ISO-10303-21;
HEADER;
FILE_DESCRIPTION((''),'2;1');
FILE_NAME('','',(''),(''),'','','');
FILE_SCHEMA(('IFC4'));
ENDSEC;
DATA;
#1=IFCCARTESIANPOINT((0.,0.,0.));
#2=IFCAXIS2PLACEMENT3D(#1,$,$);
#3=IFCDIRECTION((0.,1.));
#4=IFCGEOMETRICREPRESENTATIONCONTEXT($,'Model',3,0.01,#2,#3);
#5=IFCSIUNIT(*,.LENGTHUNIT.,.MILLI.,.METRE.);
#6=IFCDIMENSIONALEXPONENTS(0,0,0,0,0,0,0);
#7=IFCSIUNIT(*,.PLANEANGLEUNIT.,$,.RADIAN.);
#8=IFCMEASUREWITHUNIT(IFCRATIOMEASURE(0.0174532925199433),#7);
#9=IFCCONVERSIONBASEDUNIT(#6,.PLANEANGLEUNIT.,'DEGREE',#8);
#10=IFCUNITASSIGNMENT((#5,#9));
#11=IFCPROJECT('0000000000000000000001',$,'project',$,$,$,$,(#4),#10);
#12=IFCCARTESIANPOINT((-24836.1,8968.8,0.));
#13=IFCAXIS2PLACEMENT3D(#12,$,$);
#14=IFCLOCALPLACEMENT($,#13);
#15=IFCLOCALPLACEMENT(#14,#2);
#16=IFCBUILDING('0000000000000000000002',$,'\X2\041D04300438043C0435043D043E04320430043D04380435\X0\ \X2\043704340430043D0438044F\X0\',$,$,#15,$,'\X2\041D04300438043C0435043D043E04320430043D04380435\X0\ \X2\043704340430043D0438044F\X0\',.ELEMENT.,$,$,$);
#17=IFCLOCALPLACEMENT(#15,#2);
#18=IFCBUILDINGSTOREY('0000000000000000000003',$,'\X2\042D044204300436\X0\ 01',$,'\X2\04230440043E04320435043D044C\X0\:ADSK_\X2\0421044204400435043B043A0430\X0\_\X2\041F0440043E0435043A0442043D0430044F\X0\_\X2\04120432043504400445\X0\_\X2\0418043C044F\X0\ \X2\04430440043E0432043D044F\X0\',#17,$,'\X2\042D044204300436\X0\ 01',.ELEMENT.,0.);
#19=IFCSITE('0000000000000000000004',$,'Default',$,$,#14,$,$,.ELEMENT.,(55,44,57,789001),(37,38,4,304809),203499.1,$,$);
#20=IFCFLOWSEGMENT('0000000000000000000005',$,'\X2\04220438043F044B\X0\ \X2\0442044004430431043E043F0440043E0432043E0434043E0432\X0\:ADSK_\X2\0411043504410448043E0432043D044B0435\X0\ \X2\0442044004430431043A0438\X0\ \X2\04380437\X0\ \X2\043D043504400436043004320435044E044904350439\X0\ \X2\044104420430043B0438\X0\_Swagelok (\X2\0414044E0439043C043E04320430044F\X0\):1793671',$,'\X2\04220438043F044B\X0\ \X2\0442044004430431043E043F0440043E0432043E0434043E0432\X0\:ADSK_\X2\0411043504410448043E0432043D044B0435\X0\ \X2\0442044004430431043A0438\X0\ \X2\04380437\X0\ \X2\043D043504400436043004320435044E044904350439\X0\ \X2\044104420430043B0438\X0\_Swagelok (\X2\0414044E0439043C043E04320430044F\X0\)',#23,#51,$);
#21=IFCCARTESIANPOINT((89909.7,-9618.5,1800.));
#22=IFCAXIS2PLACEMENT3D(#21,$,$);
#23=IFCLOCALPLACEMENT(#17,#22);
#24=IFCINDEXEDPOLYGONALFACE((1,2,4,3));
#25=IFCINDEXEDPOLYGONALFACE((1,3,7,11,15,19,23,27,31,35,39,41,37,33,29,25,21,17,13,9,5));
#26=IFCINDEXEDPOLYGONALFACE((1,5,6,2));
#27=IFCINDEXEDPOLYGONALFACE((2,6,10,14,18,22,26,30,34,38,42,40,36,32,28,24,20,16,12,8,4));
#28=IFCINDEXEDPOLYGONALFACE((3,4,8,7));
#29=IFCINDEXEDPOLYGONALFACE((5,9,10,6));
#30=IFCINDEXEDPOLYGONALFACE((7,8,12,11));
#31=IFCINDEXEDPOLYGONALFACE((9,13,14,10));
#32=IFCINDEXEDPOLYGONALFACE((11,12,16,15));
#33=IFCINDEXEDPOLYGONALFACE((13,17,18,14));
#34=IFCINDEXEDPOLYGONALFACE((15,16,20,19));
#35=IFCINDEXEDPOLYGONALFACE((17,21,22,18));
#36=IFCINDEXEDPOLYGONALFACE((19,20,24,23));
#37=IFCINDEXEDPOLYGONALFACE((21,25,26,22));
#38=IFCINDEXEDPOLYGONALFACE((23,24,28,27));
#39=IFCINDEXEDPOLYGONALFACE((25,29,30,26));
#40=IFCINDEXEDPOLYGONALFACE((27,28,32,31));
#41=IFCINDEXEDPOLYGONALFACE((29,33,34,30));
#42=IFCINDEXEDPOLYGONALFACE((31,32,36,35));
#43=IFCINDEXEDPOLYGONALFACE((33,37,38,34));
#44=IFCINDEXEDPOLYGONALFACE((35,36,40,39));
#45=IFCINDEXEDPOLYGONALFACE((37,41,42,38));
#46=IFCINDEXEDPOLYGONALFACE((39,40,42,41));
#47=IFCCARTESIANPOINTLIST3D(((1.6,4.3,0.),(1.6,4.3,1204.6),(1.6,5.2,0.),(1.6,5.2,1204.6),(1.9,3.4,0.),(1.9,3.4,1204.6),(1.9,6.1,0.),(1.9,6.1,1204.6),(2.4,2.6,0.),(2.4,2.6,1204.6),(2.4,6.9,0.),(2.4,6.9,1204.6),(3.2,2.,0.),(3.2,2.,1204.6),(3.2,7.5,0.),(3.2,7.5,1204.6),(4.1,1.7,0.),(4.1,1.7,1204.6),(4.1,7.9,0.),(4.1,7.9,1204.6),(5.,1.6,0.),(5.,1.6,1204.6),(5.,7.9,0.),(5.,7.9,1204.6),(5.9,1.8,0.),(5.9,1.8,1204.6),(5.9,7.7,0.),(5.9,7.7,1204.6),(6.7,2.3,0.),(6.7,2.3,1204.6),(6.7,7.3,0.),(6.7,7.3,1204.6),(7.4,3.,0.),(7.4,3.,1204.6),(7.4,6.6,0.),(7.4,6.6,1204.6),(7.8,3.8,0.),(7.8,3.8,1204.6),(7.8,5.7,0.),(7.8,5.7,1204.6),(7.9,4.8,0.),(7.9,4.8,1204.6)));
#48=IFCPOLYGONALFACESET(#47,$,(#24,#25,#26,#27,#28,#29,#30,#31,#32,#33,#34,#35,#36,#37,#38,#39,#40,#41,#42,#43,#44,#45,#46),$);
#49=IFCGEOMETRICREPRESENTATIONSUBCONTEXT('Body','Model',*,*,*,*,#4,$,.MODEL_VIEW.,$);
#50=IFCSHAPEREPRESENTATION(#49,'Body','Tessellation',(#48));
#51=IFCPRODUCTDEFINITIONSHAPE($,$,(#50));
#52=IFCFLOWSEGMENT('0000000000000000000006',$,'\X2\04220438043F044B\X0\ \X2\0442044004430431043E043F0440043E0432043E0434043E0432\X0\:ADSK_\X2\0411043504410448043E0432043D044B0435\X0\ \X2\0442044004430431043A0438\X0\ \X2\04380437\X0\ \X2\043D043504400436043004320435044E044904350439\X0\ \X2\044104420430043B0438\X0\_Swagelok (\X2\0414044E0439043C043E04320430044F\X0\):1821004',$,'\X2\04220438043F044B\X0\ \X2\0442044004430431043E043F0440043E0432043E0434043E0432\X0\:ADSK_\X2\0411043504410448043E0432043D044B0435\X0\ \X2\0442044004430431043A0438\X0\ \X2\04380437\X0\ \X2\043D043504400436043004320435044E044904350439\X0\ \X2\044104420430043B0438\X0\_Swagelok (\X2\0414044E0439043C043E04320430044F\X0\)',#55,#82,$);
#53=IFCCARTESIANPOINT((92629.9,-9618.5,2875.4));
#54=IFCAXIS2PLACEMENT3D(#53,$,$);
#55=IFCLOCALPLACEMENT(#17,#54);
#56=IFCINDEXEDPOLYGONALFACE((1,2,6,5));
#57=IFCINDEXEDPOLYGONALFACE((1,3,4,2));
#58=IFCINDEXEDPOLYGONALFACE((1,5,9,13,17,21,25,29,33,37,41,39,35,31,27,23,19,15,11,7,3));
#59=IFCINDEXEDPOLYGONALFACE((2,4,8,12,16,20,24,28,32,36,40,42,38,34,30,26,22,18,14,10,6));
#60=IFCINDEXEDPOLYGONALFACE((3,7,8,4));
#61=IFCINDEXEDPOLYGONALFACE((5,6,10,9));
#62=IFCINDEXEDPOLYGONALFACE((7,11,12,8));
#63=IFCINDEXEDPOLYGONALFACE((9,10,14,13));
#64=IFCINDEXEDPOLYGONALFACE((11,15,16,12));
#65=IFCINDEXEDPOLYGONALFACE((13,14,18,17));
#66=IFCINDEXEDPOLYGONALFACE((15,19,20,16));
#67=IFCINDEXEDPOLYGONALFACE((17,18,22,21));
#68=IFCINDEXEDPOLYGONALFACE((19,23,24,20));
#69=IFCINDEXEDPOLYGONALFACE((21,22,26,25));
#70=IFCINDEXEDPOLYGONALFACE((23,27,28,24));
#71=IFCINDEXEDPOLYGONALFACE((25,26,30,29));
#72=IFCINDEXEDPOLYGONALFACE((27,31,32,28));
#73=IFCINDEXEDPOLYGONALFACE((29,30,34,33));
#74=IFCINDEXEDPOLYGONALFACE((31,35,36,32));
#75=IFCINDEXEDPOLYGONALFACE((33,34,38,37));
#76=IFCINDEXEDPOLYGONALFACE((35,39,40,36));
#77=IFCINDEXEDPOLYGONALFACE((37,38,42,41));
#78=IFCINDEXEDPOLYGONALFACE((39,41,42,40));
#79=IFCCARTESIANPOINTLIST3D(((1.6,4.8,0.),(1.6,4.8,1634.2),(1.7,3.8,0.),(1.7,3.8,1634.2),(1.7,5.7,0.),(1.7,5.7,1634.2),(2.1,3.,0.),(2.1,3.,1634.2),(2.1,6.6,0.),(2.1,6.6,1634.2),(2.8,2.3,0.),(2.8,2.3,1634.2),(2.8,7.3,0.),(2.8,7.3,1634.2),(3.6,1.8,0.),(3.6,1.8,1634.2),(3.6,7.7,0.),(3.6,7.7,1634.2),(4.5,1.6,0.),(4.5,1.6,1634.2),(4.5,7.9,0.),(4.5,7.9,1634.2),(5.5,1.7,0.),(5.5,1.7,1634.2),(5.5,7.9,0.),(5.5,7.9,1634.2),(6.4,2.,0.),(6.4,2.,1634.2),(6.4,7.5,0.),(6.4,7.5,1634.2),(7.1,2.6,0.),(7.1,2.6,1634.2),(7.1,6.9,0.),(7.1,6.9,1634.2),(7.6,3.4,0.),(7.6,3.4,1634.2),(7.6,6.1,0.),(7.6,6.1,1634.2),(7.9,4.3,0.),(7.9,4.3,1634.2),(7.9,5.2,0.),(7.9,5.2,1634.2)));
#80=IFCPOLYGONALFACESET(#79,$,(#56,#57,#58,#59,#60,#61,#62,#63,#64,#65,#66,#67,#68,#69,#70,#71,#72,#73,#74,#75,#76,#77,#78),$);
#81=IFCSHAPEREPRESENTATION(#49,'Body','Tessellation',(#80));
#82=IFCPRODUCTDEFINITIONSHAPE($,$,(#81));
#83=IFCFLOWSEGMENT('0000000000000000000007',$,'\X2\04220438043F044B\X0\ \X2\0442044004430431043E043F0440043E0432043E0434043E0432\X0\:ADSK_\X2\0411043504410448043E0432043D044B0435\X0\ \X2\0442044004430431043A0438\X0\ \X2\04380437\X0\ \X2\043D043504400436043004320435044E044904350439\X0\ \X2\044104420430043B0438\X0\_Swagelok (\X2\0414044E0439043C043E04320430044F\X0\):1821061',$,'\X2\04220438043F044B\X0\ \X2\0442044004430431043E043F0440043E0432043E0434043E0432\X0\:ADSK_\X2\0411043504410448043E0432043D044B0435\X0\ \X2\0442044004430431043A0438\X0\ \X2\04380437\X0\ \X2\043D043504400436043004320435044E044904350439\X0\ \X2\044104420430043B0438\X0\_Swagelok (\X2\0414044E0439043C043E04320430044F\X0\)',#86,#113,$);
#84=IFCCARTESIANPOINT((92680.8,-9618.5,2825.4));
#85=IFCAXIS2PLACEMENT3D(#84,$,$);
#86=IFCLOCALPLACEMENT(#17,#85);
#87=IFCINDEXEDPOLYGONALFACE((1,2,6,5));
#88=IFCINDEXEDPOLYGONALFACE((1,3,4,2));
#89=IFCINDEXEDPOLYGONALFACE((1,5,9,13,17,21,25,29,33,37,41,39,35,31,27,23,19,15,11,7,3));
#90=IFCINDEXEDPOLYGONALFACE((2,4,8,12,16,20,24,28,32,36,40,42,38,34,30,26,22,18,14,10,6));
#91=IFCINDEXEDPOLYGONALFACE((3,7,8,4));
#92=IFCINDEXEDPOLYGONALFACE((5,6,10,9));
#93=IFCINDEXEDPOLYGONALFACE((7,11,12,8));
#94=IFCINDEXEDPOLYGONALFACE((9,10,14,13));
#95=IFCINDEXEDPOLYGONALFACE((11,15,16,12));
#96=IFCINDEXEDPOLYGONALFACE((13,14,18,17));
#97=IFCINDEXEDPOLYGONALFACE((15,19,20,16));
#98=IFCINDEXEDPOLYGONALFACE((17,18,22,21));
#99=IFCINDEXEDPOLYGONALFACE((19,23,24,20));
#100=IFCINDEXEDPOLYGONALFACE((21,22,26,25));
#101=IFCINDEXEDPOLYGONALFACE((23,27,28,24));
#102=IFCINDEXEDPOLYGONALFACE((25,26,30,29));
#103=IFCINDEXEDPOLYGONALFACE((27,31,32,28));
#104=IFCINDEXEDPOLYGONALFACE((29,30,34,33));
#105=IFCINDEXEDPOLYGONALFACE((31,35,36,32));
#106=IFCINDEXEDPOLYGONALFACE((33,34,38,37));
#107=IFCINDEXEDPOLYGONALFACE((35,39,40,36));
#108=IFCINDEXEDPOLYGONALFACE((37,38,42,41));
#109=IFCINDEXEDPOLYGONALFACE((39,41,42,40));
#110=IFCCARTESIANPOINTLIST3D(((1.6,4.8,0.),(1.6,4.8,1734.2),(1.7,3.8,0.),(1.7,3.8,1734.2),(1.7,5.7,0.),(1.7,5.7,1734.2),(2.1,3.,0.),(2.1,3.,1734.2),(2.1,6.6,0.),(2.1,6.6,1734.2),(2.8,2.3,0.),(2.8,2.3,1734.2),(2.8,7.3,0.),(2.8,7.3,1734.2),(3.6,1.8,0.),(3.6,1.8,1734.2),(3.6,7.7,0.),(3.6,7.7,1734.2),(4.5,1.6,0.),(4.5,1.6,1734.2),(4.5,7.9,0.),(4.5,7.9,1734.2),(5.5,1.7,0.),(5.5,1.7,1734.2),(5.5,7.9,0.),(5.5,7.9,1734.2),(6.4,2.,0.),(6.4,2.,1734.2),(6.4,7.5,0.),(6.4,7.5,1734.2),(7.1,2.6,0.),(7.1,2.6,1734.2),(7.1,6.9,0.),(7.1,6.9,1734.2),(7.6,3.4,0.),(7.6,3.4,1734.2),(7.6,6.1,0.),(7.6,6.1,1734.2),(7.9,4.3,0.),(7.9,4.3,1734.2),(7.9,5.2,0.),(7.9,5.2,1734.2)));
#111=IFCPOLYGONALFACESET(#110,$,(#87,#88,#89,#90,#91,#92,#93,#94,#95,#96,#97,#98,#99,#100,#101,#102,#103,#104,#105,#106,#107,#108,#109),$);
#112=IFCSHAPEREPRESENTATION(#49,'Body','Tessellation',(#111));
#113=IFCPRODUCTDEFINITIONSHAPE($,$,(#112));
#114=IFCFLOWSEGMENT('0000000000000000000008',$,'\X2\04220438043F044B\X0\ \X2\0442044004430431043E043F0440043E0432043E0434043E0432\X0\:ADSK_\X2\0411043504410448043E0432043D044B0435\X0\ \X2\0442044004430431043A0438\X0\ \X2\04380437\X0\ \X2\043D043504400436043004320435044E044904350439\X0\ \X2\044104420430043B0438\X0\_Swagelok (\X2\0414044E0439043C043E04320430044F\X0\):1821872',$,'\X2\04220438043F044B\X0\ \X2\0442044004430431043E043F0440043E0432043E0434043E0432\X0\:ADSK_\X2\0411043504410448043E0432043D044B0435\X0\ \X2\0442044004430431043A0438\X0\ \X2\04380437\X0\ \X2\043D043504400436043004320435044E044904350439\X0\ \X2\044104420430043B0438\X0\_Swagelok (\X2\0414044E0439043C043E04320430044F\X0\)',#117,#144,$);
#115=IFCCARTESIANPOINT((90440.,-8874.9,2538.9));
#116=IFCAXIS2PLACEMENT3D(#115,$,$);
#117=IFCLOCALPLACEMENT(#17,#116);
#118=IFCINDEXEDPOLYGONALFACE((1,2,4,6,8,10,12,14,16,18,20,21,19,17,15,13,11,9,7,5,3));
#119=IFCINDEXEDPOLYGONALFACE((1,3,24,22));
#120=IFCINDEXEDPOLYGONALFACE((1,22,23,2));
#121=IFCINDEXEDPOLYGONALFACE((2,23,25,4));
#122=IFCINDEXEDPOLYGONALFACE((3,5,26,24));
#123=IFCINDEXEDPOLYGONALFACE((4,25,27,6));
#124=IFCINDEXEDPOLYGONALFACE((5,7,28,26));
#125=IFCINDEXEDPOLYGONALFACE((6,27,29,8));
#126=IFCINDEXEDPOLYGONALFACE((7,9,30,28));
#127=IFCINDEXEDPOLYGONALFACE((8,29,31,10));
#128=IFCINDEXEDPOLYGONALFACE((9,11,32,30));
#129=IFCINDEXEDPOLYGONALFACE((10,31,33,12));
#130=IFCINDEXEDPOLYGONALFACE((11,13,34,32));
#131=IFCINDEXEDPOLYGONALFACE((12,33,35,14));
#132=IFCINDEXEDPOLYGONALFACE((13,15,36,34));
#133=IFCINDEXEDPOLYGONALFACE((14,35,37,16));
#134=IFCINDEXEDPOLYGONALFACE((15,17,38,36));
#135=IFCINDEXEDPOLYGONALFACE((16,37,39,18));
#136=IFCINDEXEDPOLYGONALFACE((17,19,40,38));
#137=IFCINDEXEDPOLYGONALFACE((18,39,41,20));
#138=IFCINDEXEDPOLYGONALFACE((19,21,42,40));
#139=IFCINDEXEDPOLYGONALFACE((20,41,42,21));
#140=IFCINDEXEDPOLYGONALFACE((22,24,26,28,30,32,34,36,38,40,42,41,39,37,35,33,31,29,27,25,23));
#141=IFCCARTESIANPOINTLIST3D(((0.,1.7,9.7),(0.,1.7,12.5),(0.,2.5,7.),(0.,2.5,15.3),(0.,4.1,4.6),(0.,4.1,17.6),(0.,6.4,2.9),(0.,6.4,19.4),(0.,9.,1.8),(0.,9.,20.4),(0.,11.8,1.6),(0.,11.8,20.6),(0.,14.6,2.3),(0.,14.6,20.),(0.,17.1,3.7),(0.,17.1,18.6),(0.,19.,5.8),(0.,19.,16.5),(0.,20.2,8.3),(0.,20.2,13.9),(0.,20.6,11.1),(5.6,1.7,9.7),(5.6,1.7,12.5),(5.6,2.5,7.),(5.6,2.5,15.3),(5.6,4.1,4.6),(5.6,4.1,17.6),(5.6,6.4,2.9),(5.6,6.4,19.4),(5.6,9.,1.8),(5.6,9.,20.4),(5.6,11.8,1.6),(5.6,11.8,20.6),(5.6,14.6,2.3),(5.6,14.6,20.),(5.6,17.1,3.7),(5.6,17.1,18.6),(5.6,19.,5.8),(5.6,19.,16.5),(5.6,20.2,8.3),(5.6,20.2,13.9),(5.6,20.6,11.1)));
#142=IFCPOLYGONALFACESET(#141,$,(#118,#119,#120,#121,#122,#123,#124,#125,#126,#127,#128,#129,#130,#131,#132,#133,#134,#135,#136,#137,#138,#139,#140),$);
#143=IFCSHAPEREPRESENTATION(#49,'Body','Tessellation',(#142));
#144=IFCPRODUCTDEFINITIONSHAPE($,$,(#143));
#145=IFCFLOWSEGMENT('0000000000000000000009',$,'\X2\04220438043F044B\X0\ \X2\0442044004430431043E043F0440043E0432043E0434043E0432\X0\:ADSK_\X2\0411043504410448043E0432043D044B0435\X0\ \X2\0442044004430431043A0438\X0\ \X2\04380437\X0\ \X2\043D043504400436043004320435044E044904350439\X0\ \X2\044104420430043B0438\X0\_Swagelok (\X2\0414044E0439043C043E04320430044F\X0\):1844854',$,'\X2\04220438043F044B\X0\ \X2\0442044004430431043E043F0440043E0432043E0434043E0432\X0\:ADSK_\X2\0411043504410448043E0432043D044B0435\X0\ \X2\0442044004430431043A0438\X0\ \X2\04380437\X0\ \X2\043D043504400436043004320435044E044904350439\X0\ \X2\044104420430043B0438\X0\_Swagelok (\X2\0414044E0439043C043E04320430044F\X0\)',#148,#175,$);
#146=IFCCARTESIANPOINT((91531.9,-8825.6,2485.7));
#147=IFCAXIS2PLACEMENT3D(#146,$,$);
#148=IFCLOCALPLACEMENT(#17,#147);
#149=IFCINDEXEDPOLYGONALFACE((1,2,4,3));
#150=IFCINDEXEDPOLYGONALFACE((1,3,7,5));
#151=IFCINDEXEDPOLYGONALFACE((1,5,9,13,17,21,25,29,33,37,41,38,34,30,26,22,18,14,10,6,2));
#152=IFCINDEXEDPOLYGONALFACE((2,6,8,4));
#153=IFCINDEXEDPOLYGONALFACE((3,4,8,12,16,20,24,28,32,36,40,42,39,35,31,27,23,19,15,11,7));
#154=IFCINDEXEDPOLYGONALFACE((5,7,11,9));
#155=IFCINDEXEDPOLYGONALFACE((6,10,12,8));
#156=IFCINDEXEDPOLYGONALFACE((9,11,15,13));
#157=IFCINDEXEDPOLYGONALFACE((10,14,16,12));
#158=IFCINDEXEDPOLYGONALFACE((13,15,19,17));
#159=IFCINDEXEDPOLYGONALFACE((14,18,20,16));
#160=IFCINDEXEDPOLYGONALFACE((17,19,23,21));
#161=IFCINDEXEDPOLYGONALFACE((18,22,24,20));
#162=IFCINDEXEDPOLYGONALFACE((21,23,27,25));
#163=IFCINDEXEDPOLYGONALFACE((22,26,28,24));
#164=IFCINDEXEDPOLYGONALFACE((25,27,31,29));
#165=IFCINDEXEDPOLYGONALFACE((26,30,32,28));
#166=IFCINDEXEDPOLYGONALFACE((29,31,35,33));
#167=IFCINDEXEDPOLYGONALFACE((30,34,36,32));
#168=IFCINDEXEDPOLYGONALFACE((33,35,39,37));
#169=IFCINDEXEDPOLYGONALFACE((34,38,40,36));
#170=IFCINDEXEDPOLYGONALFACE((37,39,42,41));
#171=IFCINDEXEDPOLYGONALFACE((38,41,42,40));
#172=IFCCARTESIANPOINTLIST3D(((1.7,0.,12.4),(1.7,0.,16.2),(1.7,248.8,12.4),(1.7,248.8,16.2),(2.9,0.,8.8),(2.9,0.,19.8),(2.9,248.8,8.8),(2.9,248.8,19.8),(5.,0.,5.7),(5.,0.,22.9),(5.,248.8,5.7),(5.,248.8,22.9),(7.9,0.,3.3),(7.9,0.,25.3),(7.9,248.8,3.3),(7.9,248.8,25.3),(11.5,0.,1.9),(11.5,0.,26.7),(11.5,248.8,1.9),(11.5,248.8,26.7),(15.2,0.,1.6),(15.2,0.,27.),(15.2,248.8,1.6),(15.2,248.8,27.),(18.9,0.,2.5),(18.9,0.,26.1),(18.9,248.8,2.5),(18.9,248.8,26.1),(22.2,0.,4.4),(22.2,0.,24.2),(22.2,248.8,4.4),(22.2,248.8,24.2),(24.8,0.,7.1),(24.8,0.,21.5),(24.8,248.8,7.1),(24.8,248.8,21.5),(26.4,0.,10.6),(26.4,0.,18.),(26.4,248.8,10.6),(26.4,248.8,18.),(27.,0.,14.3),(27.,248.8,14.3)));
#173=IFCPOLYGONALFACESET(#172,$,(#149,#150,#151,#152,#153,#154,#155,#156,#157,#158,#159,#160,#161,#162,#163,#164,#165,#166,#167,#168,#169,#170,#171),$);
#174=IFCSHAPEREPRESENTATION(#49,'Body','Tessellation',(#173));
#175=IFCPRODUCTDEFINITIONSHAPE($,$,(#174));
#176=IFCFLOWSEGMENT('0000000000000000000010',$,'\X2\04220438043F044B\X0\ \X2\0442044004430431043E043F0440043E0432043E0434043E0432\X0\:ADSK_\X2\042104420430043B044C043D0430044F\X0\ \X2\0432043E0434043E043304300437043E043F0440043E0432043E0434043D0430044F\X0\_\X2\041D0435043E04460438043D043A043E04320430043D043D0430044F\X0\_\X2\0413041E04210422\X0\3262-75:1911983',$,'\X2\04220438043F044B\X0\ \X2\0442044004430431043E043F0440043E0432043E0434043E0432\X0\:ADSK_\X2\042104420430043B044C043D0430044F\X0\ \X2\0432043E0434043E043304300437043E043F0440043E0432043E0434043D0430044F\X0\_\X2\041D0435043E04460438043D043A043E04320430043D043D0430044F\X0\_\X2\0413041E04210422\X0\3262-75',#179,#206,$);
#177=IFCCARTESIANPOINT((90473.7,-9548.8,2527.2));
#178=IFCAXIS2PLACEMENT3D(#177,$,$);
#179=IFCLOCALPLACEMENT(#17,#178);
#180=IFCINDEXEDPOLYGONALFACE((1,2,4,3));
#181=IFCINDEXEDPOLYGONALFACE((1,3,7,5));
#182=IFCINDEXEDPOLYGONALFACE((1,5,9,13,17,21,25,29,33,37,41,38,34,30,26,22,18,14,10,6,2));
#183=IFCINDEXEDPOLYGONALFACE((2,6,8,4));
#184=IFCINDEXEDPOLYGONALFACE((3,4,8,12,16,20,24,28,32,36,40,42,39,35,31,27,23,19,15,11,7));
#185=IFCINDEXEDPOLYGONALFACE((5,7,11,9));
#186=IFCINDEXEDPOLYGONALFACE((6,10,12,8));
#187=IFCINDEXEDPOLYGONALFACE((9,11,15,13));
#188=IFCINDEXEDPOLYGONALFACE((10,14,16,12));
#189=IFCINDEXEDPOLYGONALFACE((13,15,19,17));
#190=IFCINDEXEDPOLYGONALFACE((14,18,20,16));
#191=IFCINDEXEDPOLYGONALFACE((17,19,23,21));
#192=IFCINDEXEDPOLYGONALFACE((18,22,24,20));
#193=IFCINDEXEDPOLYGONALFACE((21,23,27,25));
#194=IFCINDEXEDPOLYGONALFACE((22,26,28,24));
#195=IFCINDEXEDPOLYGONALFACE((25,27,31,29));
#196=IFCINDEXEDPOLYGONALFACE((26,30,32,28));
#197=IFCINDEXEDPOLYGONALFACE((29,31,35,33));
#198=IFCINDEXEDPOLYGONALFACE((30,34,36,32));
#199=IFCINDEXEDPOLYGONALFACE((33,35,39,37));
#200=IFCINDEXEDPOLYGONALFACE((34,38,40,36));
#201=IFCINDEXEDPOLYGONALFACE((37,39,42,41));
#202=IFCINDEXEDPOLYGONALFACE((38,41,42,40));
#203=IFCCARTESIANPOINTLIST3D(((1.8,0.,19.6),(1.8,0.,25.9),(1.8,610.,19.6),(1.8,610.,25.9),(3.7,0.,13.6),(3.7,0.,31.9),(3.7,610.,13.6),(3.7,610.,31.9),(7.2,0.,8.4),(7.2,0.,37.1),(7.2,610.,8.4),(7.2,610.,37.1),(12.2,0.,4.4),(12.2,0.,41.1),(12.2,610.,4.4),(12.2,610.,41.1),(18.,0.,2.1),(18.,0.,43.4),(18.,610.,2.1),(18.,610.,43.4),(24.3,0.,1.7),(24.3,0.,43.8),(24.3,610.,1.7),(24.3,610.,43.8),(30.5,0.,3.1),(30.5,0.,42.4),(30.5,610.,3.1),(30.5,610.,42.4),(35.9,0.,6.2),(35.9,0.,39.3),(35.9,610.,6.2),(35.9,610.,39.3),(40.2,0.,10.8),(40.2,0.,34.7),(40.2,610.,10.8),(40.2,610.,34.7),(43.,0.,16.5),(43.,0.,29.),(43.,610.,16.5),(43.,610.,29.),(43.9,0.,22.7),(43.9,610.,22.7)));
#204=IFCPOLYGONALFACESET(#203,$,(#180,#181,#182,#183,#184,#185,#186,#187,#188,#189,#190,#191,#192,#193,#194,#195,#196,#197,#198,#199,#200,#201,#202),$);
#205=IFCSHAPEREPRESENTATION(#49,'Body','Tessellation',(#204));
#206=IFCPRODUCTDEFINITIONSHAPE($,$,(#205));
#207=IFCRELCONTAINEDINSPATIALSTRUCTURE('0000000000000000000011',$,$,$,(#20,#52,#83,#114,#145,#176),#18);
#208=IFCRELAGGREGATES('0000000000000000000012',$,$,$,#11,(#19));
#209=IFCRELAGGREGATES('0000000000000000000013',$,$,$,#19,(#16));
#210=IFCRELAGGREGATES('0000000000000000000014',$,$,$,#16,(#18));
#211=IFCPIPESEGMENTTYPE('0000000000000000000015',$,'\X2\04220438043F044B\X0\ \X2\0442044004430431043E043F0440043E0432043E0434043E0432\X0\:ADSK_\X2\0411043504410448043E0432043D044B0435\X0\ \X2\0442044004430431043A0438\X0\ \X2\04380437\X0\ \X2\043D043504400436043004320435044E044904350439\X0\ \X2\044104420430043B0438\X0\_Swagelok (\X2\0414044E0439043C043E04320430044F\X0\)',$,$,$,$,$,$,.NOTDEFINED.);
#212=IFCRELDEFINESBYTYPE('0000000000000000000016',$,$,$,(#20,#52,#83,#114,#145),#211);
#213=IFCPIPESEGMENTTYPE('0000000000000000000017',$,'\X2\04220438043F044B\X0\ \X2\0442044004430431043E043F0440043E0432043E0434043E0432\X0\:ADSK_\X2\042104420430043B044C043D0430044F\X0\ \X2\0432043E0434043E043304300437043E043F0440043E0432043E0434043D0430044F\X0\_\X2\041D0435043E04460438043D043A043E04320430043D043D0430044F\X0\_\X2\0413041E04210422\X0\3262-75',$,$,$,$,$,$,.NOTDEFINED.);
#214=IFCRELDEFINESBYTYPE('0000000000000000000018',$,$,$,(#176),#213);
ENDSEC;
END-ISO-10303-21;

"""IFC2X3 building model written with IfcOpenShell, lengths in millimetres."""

from ifc_helpers import new_model, entity, si_unit, converted_unit, direction, frame, origin, origin_2d_with_axis, place, context, subcontext, project, spatial, circle, extrude, type_object, element, save


model = new_model("IFC2X3")

# Units and contexts
model_context = context("Model", 3, precision=0.01, world=origin(), true_north=direction((0.0, 1.0)))
body_context = subcontext(model_context, "Body", "Model", "MODEL_VIEW")
ifc_project = project(units=[si_unit("LENGTHUNIT", "METRE", prefix="MILLI"), converted_unit("PLANEANGLEUNIT", "DEGREE", entity("IfcRatioMeasure", 0.0174532925199433), si_unit("PLANEANGLEUNIT", "RADIAN"), dimensions=[0, 0, 0, 0, 0, 0, 0])], contexts=[model_context])

# Site, building, storey
site_placement = place(None, frame((-24836.1, 8968.8, 0.0)))
site = spatial("IfcSite", under=ifc_project, at=site_placement, Name="Default", CompositionType="ELEMENT", RefLatitude=(55, 44, 57, 789001), RefLongitude=(37, 38, 4, 304809), RefElevation=203499.1)
building_placement = place(site_placement, origin())
building = spatial("IfcBuilding", under=site, at=building_placement, Name="Наименование здания", LongName="Наименование здания", CompositionType="ELEMENT")
storey_placement = place(building_placement, origin())
storey = spatial("IfcBuildingStorey", under=building, at=storey_placement, Name="Этаж 01", ObjectType="Уровень:ADSK_Стрелка_Проектная_Вверх_Имя уровня", LongName="Этаж 01", CompositionType="ELEMENT", Elevation=0.0)

# Flow segments
pipe_segment_type_1 = type_object("IfcPipeSegmentType", Name="Типы трубопроводов:ADSK_Бесшовные трубки из нержавеющей стали_Swagelok (Дюймовая)", PredefinedType="NOTDEFINED")
flow_segment_1_placement = place(storey_placement, frame((89909.7, -9618.5, 1800.0)))
element("IfcFlowSegment", 1, at=flow_segment_1_placement, inside=storey, type_object=pipe_segment_type_1, Name="Типы трубопроводов:ADSK_Бесшовные трубки из нержавеющей стали_Swagelok (Дюймовая):1793671", ObjectType="Типы трубопроводов:ADSK_Бесшовные трубки из нержавеющей стали_Swagelok (Дюймовая)", context=body_context, shape_type="SweptSolid", body=[
    extrude(circle(Radius=3.2, at=origin_2d_with_axis()), frame((4.8, 4.8, 0.0)), (0.0, 0.0, 1.0), 1204.6),
])
flow_segment_2_placement = place(storey_placement, frame((92629.9, -9618.5, 2875.4)))
element("IfcFlowSegment", 2, at=flow_segment_2_placement, inside=storey, type_object=pipe_segment_type_1, Name="Типы трубопроводов:ADSK_Бесшовные трубки из нержавеющей стали_Swagelok (Дюймовая):1821004", ObjectType="Типы трубопроводов:ADSK_Бесшовные трубки из нержавеющей стали_Swagelok (Дюймовая)", context=body_context, shape_type="SweptSolid", body=[
    extrude(circle(Radius=3.2, at=origin_2d_with_axis()), frame((4.8, 4.8, 0.0), z_axis=(0.0, 0.0, 1.0), x_axis=(-1.0, 0.0, 0.0)), (0.0, 0.0, 1.0), 1634.2),
])
flow_segment_3_placement = place(storey_placement, frame((92680.8, -9618.5, 2825.4)))
element("IfcFlowSegment", 3, at=flow_segment_3_placement, inside=storey, type_object=pipe_segment_type_1, Name="Типы трубопроводов:ADSK_Бесшовные трубки из нержавеющей стали_Swagelok (Дюймовая):1821061", ObjectType="Типы трубопроводов:ADSK_Бесшовные трубки из нержавеющей стали_Swagelok (Дюймовая)", context=body_context, shape_type="SweptSolid", body=[
    extrude(circle(Radius=3.2, at=origin_2d_with_axis()), frame((4.8, 4.8, 0.0), z_axis=(0.0, 0.0, 1.0), x_axis=(-1.0, 0.0, 0.0)), (0.0, 0.0, 1.0), 1734.2),
])
flow_segment_4_placement = place(storey_placement, frame((90440.0, -8874.9, 2538.9)))
element("IfcFlowSegment", 4, at=flow_segment_4_placement, inside=storey, type_object=pipe_segment_type_1, Name="Типы трубопроводов:ADSK_Бесшовные трубки из нержавеющей стали_Swagelok (Дюймовая):1821872", ObjectType="Типы трубопроводов:ADSK_Бесшовные трубки из нержавеющей стали_Swagelok (Дюймовая)", context=body_context, shape_type="SweptSolid", body=[
    extrude(circle(Radius=9.5, at=origin_2d_with_axis()), frame((0.0, 11.1, 11.1), z_axis=(1.0, 0.0, 0.0), x_axis=(0.0, 1.0, 0.0)), (0.0, 0.0, 1.0), 5.6),
])
flow_segment_5_placement = place(storey_placement, frame((91531.9, -8825.6, 2485.7)))
element("IfcFlowSegment", 5, at=flow_segment_5_placement, inside=storey, type_object=pipe_segment_type_1, Name="Типы трубопроводов:ADSK_Бесшовные трубки из нержавеющей стали_Swagelok (Дюймовая):1844854", ObjectType="Типы трубопроводов:ADSK_Бесшовные трубки из нержавеющей стали_Swagelok (Дюймовая)", context=body_context, shape_type="SweptSolid", body=[
    extrude(circle(Radius=12.7, at=origin_2d_with_axis()), frame((14.3, 0.0, 14.3), z_axis=(0.0, 1.0, 0.0), x_axis=(1.0, 0.0, 0.0)), (0.0, 0.0, 1.0), 248.8),
])
pipe_segment_type_2 = type_object("IfcPipeSegmentType", Name="Типы трубопроводов:ADSK_Стальная водогазопроводная_Неоцинкованная_ГОСТ3262-75", PredefinedType="NOTDEFINED")
flow_segment_6_placement = place(storey_placement, frame((90473.7, -9548.8, 2527.2)))
element("IfcFlowSegment", 6, at=flow_segment_6_placement, inside=storey, type_object=pipe_segment_type_2, Name="Типы трубопроводов:ADSK_Стальная водогазопроводная_Неоцинкованная_ГОСТ3262-75:1911983", ObjectType="Типы трубопроводов:ADSK_Стальная водогазопроводная_Неоцинкованная_ГОСТ3262-75", context=body_context, shape_type="SweptSolid", body=[
    extrude(circle(Radius=21.1, at=origin_2d_with_axis()), frame((22.8, 0.0, 22.8), z_axis=(0.0, 1.0, 0.0), x_axis=(1.0, 0.0, 0.0)), (0.0, 0.0, 1.0), 610.0),
])

save(model, "model.ifc")
